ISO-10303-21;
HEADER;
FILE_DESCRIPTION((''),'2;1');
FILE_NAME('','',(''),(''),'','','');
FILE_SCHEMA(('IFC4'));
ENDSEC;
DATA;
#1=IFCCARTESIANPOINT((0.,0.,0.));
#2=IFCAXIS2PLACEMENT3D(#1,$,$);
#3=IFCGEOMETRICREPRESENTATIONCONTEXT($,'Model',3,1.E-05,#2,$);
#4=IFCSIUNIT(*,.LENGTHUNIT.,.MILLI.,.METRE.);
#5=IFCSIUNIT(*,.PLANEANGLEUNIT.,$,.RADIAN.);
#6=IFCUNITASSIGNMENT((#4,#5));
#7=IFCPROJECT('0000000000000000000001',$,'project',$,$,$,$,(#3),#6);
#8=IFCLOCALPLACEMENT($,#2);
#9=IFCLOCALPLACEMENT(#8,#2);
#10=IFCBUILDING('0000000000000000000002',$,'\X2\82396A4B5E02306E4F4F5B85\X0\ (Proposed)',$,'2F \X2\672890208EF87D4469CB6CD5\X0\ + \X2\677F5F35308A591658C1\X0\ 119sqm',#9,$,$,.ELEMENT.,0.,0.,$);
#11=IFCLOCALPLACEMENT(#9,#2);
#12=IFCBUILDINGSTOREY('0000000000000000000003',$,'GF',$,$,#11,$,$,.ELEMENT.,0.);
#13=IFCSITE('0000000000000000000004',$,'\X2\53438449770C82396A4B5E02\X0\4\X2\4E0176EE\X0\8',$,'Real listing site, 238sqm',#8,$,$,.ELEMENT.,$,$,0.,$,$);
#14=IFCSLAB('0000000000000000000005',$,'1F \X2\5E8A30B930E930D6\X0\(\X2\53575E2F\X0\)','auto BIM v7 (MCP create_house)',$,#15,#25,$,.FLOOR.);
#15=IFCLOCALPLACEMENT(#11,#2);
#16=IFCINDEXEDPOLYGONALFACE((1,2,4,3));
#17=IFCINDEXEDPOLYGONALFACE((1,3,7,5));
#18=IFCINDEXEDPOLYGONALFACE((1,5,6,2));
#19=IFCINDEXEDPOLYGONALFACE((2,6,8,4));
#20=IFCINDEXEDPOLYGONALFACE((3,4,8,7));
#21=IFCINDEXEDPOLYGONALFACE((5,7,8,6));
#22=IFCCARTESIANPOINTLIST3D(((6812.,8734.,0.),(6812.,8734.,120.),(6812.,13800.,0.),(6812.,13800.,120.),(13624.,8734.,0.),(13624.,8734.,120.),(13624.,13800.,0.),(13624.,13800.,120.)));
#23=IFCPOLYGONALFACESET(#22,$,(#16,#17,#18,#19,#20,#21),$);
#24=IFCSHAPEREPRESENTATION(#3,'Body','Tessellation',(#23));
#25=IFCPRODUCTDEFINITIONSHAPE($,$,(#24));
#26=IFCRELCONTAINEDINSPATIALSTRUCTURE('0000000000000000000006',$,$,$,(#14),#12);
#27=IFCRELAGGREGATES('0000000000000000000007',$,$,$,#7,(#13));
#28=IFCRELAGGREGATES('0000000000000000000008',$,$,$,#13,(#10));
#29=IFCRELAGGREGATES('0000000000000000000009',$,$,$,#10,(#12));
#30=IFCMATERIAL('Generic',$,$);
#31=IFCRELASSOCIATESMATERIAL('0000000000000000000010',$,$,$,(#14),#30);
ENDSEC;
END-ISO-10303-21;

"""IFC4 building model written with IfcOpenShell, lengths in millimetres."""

from ifc_helpers import new_model, si_unit, frame, frame_2d, origin, place, context, project, spatial, rectangle, extrude, material, element, save


model = new_model("IFC4")

# Units and contexts
model_context = context("Model", 3, precision=1e-05, world=origin())
ifc_project = project(units=[si_unit("LENGTHUNIT", "METRE", prefix="MILLI"), si_unit("PLANEANGLEUNIT", "RADIAN")], contexts=[model_context])

# Site, building, storey
site_placement = place(None, origin())
site = spatial("IfcSite", under=ifc_project, at=site_placement, Name="千葉県船橋市4丁目8", ObjectType="Real listing site, 238sqm", CompositionType="ELEMENT", RefElevation=0.0)
building_placement = place(site_placement, origin())
building = spatial("IfcBuilding", under=site, at=building_placement, Name="船橋市の住宅 (Proposed)", ObjectType="2F 木造軸組構法 + 板張り外壁 119sqm", CompositionType="ELEMENT", ElevationOfRefHeight=0.0, ElevationOfTerrain=0.0)
storey_placement = place(building_placement, origin())
storey = spatial("IfcBuildingStorey", under=building, at=storey_placement, Name="GF", CompositionType="ELEMENT", Elevation=0.0)

# Slab
ifc_material = material(Name="Generic")
slab_1_placement = place(storey_placement, frame((3406.0, 4367.0, 0.0)))
element("IfcSlab", 1, at=slab_1_placement, inside=storey, material=ifc_material, Name="1F 床スラブ(南帯)", Description="auto BIM v7 (MCP create_house)", PredefinedType="FLOOR", context=model_context, shape_type="SweptSolid", body=[
    extrude(rectangle(XDim=6812.0, YDim=5066.0, at=frame_2d((3406.0, 2533.0))), frame((3406.0, 4367.0, 0.0)), (0.0, 0.0, 1.0), 120.0),
])

save(model, "model.ifc")
